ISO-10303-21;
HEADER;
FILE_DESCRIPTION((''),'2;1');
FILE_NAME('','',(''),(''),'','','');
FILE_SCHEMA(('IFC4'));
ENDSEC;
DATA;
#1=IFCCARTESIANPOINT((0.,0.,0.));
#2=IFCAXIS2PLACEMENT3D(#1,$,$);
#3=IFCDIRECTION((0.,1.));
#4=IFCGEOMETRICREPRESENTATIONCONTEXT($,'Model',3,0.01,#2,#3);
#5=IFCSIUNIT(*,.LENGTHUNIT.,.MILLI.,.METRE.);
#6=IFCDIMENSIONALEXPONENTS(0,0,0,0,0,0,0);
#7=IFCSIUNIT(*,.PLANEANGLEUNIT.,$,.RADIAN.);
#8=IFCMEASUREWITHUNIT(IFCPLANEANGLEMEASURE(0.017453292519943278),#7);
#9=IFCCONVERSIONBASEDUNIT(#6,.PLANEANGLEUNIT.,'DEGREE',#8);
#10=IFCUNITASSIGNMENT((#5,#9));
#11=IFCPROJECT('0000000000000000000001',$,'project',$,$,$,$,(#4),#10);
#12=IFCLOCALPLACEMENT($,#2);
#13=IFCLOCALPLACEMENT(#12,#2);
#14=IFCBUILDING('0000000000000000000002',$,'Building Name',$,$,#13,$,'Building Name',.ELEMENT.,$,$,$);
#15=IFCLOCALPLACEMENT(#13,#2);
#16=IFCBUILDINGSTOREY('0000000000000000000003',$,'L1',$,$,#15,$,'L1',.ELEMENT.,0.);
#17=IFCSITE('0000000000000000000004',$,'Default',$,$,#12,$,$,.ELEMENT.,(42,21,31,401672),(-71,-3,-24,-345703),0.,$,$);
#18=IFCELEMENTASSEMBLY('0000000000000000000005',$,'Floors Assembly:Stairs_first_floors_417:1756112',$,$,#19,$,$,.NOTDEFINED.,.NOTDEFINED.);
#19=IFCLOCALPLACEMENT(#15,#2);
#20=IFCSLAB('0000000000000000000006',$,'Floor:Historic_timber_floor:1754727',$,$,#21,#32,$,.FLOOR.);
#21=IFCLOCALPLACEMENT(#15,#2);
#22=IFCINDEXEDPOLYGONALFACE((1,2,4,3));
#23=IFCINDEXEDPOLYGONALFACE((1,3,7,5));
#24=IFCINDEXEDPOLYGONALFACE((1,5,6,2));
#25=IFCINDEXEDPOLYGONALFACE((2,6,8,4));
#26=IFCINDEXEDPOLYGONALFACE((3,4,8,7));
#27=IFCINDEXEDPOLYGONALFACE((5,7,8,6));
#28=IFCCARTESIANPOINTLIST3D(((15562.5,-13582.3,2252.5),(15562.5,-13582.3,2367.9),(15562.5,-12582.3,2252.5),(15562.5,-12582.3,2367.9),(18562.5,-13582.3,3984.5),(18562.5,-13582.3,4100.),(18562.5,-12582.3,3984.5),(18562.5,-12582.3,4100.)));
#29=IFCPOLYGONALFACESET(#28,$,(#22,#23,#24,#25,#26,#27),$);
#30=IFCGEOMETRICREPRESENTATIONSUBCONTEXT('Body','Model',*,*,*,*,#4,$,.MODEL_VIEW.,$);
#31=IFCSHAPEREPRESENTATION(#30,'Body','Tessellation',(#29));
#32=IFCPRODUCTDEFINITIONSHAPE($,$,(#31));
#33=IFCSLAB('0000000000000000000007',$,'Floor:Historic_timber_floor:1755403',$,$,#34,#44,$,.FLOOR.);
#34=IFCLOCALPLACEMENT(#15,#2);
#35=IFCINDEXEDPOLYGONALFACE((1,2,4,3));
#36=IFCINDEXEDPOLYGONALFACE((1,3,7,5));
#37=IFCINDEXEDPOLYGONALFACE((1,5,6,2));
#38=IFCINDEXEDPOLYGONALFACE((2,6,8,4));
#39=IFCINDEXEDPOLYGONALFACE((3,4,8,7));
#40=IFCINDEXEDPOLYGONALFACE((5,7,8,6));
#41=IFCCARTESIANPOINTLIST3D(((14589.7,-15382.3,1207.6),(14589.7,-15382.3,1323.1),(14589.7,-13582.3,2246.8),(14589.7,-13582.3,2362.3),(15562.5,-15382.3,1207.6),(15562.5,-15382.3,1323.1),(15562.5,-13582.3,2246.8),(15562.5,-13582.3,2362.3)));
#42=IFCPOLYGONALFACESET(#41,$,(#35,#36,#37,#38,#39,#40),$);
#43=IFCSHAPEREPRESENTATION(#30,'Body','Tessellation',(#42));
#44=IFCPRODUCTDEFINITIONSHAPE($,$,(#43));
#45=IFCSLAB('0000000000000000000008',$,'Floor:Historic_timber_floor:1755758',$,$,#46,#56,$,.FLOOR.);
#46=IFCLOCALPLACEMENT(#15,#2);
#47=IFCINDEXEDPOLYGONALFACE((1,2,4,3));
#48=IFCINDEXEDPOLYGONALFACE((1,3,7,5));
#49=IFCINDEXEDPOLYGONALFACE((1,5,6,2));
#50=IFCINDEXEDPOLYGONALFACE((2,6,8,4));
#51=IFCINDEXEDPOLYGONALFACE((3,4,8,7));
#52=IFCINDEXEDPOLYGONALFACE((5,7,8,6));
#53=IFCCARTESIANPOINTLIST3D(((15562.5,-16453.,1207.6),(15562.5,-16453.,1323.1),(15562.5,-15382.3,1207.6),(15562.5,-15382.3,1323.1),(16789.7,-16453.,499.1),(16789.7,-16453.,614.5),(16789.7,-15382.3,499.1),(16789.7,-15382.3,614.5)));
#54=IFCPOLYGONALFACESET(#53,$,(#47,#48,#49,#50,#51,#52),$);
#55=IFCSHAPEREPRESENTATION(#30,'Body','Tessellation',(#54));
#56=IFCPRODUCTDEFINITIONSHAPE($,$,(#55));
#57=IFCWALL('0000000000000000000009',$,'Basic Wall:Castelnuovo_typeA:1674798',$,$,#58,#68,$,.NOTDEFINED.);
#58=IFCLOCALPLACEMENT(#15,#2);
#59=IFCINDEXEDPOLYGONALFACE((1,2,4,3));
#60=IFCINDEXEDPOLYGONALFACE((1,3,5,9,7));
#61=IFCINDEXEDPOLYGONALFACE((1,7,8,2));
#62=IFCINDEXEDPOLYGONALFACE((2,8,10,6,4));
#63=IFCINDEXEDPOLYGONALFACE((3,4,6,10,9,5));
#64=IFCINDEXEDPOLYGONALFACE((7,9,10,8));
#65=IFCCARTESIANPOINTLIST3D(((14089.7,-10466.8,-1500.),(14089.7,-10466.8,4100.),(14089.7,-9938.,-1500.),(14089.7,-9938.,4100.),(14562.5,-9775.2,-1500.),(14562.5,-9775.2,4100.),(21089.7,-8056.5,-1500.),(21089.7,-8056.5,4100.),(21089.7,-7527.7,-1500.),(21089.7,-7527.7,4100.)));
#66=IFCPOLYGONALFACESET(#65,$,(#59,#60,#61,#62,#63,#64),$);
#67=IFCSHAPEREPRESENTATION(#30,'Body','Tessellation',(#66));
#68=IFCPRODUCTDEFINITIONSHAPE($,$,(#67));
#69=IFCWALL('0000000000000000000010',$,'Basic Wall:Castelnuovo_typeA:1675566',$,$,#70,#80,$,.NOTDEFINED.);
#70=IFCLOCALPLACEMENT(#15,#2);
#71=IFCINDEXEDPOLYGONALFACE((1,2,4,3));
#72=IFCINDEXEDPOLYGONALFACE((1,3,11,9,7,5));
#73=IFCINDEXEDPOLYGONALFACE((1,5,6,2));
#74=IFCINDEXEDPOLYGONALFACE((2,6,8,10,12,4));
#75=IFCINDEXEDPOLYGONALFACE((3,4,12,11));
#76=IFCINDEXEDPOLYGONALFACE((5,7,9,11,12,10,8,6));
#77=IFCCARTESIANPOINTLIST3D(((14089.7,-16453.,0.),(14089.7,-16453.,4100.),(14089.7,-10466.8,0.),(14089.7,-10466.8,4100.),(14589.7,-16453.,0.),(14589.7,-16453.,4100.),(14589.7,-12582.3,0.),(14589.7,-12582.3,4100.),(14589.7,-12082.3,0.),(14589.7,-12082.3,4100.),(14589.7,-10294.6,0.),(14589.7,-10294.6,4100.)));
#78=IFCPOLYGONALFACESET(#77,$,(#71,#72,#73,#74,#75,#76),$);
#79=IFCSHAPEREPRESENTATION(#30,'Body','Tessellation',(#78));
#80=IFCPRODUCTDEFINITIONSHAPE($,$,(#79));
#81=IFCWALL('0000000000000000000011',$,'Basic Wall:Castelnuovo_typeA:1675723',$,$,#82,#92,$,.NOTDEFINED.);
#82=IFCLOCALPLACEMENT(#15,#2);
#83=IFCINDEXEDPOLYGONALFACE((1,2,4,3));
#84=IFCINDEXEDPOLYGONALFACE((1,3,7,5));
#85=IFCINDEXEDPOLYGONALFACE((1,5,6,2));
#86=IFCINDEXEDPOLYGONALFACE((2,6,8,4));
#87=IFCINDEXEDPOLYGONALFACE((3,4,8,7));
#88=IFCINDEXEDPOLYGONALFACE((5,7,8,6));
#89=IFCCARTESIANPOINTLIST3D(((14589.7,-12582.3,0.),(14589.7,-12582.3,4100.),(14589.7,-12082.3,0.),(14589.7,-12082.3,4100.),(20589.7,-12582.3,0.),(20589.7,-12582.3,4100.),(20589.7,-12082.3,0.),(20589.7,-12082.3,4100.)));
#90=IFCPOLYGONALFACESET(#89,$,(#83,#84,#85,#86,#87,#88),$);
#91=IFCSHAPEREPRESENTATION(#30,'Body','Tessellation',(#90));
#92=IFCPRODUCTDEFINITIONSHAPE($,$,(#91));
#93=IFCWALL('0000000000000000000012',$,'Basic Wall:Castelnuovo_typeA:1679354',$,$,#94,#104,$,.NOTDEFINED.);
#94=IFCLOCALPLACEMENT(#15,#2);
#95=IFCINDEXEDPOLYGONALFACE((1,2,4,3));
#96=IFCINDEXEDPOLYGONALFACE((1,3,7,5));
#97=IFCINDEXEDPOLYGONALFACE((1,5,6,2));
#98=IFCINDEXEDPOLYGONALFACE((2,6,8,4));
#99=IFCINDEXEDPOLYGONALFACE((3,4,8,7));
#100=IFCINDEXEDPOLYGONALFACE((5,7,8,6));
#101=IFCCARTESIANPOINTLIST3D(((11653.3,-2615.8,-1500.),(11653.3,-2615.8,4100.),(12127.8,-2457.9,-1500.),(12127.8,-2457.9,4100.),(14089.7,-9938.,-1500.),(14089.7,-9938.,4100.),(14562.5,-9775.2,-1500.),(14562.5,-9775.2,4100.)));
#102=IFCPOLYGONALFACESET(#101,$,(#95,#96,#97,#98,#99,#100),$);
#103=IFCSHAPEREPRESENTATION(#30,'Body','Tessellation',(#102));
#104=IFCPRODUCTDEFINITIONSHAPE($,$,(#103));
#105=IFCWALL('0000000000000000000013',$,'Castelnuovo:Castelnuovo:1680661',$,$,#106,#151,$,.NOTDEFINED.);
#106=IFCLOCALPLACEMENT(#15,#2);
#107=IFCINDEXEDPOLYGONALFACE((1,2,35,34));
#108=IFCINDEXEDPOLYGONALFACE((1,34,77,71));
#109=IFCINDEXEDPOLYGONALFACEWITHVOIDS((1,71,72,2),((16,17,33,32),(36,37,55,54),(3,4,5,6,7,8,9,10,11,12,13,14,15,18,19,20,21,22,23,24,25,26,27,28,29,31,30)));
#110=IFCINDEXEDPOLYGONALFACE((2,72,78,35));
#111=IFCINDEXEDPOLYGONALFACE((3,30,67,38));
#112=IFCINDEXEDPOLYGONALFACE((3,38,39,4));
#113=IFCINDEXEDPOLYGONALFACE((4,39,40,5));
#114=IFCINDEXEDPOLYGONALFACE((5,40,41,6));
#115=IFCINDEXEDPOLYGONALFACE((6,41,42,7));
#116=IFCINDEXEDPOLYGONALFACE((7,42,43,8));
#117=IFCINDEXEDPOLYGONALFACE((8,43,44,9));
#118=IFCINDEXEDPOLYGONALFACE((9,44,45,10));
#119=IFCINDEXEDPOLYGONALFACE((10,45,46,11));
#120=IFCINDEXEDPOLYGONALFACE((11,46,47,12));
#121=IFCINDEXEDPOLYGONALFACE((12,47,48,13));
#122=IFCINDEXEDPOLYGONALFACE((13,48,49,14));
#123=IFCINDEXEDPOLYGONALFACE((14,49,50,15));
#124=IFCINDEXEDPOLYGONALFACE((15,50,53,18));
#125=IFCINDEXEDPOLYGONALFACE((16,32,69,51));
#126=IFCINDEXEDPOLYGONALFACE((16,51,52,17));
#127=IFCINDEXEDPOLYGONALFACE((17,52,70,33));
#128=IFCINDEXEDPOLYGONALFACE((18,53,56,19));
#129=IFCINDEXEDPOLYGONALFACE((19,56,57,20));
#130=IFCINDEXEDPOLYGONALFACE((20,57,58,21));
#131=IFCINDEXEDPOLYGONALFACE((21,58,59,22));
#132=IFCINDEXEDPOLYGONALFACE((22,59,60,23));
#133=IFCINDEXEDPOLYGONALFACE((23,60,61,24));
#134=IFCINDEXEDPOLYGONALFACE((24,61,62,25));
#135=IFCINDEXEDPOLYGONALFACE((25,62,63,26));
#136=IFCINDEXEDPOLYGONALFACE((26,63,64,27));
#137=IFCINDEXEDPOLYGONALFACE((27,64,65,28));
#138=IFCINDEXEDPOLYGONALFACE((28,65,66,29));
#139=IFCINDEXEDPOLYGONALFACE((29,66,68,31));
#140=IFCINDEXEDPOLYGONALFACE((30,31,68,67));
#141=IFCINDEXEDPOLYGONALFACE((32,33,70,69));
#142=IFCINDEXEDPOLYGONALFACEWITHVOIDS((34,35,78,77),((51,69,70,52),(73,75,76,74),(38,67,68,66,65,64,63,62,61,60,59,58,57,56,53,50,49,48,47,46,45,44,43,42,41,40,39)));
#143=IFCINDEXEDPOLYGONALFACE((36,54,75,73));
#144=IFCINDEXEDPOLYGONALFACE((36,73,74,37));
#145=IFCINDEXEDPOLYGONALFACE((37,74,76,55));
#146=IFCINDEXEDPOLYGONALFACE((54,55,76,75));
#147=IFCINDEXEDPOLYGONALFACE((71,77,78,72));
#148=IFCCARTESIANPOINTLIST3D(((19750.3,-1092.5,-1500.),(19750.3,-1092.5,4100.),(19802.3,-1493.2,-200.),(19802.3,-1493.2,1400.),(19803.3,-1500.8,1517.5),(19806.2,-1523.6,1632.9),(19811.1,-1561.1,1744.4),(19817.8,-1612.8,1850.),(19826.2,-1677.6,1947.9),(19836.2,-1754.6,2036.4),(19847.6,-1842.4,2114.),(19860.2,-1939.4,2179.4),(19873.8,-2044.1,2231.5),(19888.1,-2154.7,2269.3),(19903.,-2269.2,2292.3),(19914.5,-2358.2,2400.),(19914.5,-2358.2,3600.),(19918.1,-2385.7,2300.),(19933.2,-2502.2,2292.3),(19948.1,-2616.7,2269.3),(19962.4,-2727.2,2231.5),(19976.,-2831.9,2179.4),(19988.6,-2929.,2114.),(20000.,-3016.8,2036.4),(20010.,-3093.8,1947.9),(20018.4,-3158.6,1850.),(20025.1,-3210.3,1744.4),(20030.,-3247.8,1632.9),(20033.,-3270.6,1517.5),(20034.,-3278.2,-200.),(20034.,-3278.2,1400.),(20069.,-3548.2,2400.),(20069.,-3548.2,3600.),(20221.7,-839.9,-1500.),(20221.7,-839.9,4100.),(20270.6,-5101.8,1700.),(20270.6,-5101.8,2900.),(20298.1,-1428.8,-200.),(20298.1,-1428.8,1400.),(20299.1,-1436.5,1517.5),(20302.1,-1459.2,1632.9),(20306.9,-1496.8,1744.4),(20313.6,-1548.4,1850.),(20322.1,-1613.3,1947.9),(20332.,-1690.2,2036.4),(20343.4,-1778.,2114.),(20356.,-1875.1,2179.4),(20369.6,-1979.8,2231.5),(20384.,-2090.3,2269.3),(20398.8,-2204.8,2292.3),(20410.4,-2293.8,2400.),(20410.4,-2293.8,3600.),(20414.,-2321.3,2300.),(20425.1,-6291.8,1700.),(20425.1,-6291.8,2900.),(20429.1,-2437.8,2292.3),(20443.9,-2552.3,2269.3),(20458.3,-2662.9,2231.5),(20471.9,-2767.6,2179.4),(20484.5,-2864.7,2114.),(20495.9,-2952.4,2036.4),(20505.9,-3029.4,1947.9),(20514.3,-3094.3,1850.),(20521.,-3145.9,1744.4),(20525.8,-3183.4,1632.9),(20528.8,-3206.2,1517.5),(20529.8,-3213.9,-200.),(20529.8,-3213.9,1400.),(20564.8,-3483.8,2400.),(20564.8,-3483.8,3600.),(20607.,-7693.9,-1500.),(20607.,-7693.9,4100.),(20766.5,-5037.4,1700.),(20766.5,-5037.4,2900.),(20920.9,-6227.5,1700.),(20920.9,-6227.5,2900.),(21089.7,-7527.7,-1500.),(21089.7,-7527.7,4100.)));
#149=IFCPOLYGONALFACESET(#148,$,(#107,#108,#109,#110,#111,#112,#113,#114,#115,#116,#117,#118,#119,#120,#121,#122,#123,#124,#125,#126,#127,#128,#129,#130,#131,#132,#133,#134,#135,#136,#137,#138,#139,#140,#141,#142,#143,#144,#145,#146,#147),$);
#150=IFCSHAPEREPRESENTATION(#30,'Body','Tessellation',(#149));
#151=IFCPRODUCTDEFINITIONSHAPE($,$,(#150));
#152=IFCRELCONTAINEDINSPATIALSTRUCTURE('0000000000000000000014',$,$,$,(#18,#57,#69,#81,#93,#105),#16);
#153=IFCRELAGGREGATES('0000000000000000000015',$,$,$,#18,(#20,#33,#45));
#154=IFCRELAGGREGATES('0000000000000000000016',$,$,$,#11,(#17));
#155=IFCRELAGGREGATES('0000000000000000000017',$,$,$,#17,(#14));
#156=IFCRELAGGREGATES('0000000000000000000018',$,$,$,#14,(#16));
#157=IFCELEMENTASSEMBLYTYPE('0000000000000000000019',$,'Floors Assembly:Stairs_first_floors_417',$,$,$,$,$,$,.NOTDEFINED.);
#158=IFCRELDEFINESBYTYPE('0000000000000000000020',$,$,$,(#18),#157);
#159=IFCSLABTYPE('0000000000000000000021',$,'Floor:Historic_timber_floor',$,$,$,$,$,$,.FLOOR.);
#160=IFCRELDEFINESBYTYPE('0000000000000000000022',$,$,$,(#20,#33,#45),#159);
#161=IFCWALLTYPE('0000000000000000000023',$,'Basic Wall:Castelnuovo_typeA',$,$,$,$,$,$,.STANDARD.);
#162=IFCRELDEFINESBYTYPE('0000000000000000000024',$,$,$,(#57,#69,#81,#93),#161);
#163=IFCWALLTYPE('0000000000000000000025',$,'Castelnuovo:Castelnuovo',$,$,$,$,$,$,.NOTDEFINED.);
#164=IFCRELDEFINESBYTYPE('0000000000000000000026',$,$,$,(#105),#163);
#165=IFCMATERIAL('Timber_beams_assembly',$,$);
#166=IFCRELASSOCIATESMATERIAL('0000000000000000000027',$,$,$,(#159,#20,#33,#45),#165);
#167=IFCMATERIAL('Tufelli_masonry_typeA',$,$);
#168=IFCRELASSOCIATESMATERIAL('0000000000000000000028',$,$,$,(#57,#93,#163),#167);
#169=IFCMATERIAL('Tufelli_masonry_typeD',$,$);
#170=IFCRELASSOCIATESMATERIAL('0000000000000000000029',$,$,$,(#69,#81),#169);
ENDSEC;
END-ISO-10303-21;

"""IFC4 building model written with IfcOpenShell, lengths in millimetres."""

from ifc_helpers import new_model, entity, si_unit, converted_unit, direction, frame, frame_2d, origin, place, context, subcontext, project, spatial, line, arc, indexed_curve, rectangle, outline, extrude, material, type_object, element, aggregate, save


model = new_model("IFC4")

# Units and contexts
model_context = context("Model", 3, precision=0.01, world=origin(), true_north=direction((0.0, 1.0)))
body_context = subcontext(model_context, "Body", "Model", "MODEL_VIEW")
ifc_project = project(units=[si_unit("LENGTHUNIT", "METRE", prefix="MILLI"), converted_unit("PLANEANGLEUNIT", "DEGREE", entity("IfcPlaneAngleMeasure", 0.017453292519943278), si_unit("PLANEANGLEUNIT", "RADIAN"), dimensions=[0, 0, 0, 0, 0, 0, 0])], contexts=[model_context])

# Site, building, storey
site_placement = place(None, origin())
site = spatial("IfcSite", under=ifc_project, at=site_placement, Name="Default", CompositionType="ELEMENT", RefLatitude=(42, 21, 31, 401672), RefLongitude=(-71, -3, -24, -345703), RefElevation=0.0)
building_placement = place(site_placement, origin())
building = spatial("IfcBuilding", under=site, at=building_placement, Name="Building Name", LongName="Building Name", CompositionType="ELEMENT")
storey_placement = place(building_placement, origin())
storey = spatial("IfcBuildingStorey", under=building, at=storey_placement, Name="L1", LongName="L1", CompositionType="ELEMENT", Elevation=0.0)

# Element assembly, slabs
element_assembly_type = type_object("IfcElementAssemblyType", Name="Floors Assembly:Stairs_first_floors_417", PredefinedType="NOTDEFINED")
assembly_placement = place(storey_placement, origin())
assembly = element("IfcElementAssembly", 1, at=assembly_placement, inside=storey, type_object=element_assembly_type, Name="Floors Assembly:Stairs_first_floors_417:1756112", AssemblyPlace="NOTDEFINED", PredefinedType="NOTDEFINED")
ifc_material_1 = material(Name="Timber_beams_assembly")
slab_type = type_object("IfcSlabType", Name="Floor:Historic_timber_floor", PredefinedType="FLOOR", material=ifc_material_1)
slab_1_placement = place(assembly_placement, frame((15562.5, -13582.3, 2252.5)))
slab_1 = element("IfcSlab", 2, at=slab_1_placement, type_object=slab_type, material=ifc_material_1, Name="Floor:Historic_timber_floor:1754727", PredefinedType="FLOOR", context=body_context, shape_type="SweptSolid", body=[
    extrude(rectangle(XDim=1000.0, YDim=3464.1, at=frame_2d((-1732.1, -500.0), x_axis=(0.0, -1.0))), frame((3000.0, 1000.0, 1847.5), z_axis=(-0.5, 0.0, 0.866025), x_axis=(0.866025, 0.0, 0.5)), (-0.5, 0.0, -0.866025), 115.5),
])
slab_2_placement = place(assembly_placement, frame((14589.7, -15382.3, 1207.6)))
slab_2 = element("IfcSlab", 3, at=slab_2_placement, type_object=slab_type, material=ifc_material_1, Name="Floor:Historic_timber_floor:1755403", PredefinedType="FLOOR", context=body_context, shape_type="SweptSolid", body=[
    extrude(rectangle(XDim=972.8, YDim=2078.5, at=frame_2d((486.4, -1039.2), x_axis=(1.0, 0.0))), frame((0.0, 1800.0, 1154.7), z_axis=(0.0, -0.5, 0.866025), x_axis=(1.0, 0.0, 0.0)), (0.0, -0.5, -0.866025), 115.5),
])
slab_3_placement = place(assembly_placement, frame((15562.5, -16453.0, 499.1)))
slab_3 = element("IfcSlab", 4, at=slab_3_placement, type_object=slab_type, material=ifc_material_1, Name="Floor:Historic_timber_floor:1755758", PredefinedType="FLOOR", context=body_context, shape_type="SweptSolid", body=[
    extrude(rectangle(XDim=1070.7, YDim=1417.1, at=frame_2d((708.5, 535.3), x_axis=(0.0, -1.0))), frame((0.0, 0.0, 824.0), z_axis=(0.5, 0.0, 0.866025), x_axis=(0.866025, 0.0, -0.5)), (0.5, 0.0, -0.866025), 115.5),
])
aggregate(assembly, [slab_1, slab_2, slab_3])

# Walls
ifc_material_2 = material(Name="Tufelli_masonry_typeA")
wall_type_1 = type_object("IfcWallType", Name="Basic Wall:Castelnuovo_typeA", PredefinedType="STANDARD")
wall_1_placement = place(storey_placement, frame((14008.3, -10230.4, -1500.0), z_axis=(0.0, 0.0, 1.0), x_axis=(0.945519, 0.325568, 0.0)))
element("IfcWall", 5, at=wall_1_placement, inside=storey, type_object=wall_type_1, material=ifc_material_2, Name="Basic Wall:Castelnuovo_typeA:1674798", PredefinedType="NOTDEFINED", context=body_context, shape_type="SweptSolid", body=[
    extrude(outline(indexed_curve([(7403.3, -250.0), (7575.5, 250.0), (672.2, 250.0), (172.2, 250.0), (0.0, -250.0), (7403.3, -250.0)], self_intersect=False)), origin(), (0.0, 0.0, 1.0), 5600.0),
])
ifc_material_3 = material(Name="Tufelli_masonry_typeD")
wall_2_placement = place(storey_placement, frame((14339.7, -16453.0, 0.0), z_axis=(0.0, 0.0, 1.0), x_axis=(0.0, 1.0, 0.0)))
element("IfcWall", 6, at=wall_2_placement, inside=storey, type_object=wall_type_1, material=ifc_material_3, Name="Basic Wall:Castelnuovo_typeA:1675566", PredefinedType="NOTDEFINED", context=body_context, shape_type="SweptSolid", body=[
    extrude(outline(indexed_curve([(6158.4, -250.0), (5986.3, 250.0), (0.0, 250.0), (0.0, -250.0), (3870.7, -250.0), (4370.7, -250.0), (6158.4, -250.0)], self_intersect=False)), origin(), (0.0, 0.0, 1.0), 4100.0),
])
wall_3_placement = place(storey_placement, frame((14589.7, -12332.3, 0.0)))
element("IfcWall", 7, at=wall_3_placement, inside=storey, type_object=wall_type_1, material=ifc_material_3, Name="Basic Wall:Castelnuovo_typeA:1675723", PredefinedType="NOTDEFINED", context=body_context, shape_type="SweptSolid", body=[
    extrude(outline(indexed_curve([(6000.0, 250.0), (0.0, 250.0), (0.0, -250.0), (6000.0, -250.0), (6000.0, 250.0)], self_intersect=False)), origin(), (0.0, 0.0, 1.0), 4100.0),
])
wall_4_placement = place(storey_placement, frame((11890.5, -2536.8, -1500.0), z_axis=(0.0, 0.0, 1.0), x_axis=(0.315716, -0.948854, 0.0)))
element("IfcWall", 8, at=wall_4_placement, inside=storey, type_object=wall_type_1, material=ifc_material_2, Name="Basic Wall:Castelnuovo_typeA:1679354", PredefinedType="NOTDEFINED", context=body_context, shape_type="SweptSolid", body=[
    extrude(outline(indexed_curve([(7716.9, -250.0), (7711.7, 250.0), (0.0, 250.0), (0.0, -250.0), (7716.9, -250.0)], self_intersect=False)), origin(), (0.0, 0.0, 1.0), 5600.0),
])

# Wall, openings
wall_type_2 = type_object("IfcWallType", Name="Castelnuovo:Castelnuovo", PredefinedType="NOTDEFINED", material=ifc_material_2)
wall_5_placement = place(storey_placement, frame((19750.3, -7693.9, -1500.0), z_axis=(0.0, 0.0, 1.0), x_axis=(0.0, 1.0, 0.0)))
wall_5 = element("IfcWall", 9, at=wall_5_placement, inside=storey, type_object=wall_type_2, Name="Castelnuovo:Castelnuovo:1680661", PredefinedType="NOTDEFINED", context=body_context, shape_type="SweptSolid", body=[
    extrude(outline(indexed_curve([(-929.1, -3281.7), (-418.7, -3281.7), (937.9, 3324.4), (409.9, 3239.0), (-929.1, -3281.7)], self_intersect=False)), frame((3405.4, -666.9, 0.0), z_axis=(0.0, 0.0, 1.0), x_axis=(0.325568, -0.945519, 0.0)), (0.0, 0.0, 1.0), 5600.0),
])
opening_1_placement = place(wall_5_placement, origin())
element("IfcOpeningElement", 10, at=opening_1_placement, cuts=wall_5, PredefinedType="OPENING", context=body_context, shape_type="SweptSolid", body=[
    extrude(outline(indexed_curve([(-600.0, -600.0), (600.0, -600.0), (600.0, 600.0), (-600.0, 600.0), (-600.0, -600.0)], self_intersect=False)), frame((1994.5, -577.7, 3800.0), z_axis=(0.128709, -0.991682, 0.0), x_axis=(0.0, 0.0, 1.0)), (0.0, 0.0, 1.0), 590.0),
])
opening_2_placement = place(wall_5_placement, origin())
element("IfcOpeningElement", 11, at=opening_2_placement, cuts=wall_5, PredefinedType="OPENING", context=body_context, shape_type="SweptSolid", body=[
    extrude(outline(indexed_curve([(-600.0, -600.0), (600.0, -600.0), (600.0, 600.0), (-600.0, 600.0), (-600.0, -600.0)], self_intersect=False)), frame((4738.1, -221.7, 4500.0), z_axis=(0.128709, -0.991682, 0.0), x_axis=(0.0, 0.0, 1.0)), (0.0, 0.0, 1.0), 590.0),
])
opening_3_placement = place(wall_5_placement, origin())
element("IfcOpeningElement", 12, at=opening_3_placement, cuts=wall_5, PredefinedType="OPENING", context=body_context, shape_type="SweptSolid", body=[
    extrude(outline(indexed_curve([(-800.0, -900.0), (800.0, -900.0), (800.0, 900.0), (-800.0, 900.0), (-1700.0, 0.0)], segments=[line(1, 2, 3, 4), arc(4, 5, 1)], self_intersect=False)), frame((5375.1, -683.5, 2100.0), z_axis=(-0.128709, 0.991682, 0.0), x_axis=(0.0, 0.0, -1.0)), (0.0, 0.0, 1.0), 1590.0),
])

save(model, "model.ifc")
